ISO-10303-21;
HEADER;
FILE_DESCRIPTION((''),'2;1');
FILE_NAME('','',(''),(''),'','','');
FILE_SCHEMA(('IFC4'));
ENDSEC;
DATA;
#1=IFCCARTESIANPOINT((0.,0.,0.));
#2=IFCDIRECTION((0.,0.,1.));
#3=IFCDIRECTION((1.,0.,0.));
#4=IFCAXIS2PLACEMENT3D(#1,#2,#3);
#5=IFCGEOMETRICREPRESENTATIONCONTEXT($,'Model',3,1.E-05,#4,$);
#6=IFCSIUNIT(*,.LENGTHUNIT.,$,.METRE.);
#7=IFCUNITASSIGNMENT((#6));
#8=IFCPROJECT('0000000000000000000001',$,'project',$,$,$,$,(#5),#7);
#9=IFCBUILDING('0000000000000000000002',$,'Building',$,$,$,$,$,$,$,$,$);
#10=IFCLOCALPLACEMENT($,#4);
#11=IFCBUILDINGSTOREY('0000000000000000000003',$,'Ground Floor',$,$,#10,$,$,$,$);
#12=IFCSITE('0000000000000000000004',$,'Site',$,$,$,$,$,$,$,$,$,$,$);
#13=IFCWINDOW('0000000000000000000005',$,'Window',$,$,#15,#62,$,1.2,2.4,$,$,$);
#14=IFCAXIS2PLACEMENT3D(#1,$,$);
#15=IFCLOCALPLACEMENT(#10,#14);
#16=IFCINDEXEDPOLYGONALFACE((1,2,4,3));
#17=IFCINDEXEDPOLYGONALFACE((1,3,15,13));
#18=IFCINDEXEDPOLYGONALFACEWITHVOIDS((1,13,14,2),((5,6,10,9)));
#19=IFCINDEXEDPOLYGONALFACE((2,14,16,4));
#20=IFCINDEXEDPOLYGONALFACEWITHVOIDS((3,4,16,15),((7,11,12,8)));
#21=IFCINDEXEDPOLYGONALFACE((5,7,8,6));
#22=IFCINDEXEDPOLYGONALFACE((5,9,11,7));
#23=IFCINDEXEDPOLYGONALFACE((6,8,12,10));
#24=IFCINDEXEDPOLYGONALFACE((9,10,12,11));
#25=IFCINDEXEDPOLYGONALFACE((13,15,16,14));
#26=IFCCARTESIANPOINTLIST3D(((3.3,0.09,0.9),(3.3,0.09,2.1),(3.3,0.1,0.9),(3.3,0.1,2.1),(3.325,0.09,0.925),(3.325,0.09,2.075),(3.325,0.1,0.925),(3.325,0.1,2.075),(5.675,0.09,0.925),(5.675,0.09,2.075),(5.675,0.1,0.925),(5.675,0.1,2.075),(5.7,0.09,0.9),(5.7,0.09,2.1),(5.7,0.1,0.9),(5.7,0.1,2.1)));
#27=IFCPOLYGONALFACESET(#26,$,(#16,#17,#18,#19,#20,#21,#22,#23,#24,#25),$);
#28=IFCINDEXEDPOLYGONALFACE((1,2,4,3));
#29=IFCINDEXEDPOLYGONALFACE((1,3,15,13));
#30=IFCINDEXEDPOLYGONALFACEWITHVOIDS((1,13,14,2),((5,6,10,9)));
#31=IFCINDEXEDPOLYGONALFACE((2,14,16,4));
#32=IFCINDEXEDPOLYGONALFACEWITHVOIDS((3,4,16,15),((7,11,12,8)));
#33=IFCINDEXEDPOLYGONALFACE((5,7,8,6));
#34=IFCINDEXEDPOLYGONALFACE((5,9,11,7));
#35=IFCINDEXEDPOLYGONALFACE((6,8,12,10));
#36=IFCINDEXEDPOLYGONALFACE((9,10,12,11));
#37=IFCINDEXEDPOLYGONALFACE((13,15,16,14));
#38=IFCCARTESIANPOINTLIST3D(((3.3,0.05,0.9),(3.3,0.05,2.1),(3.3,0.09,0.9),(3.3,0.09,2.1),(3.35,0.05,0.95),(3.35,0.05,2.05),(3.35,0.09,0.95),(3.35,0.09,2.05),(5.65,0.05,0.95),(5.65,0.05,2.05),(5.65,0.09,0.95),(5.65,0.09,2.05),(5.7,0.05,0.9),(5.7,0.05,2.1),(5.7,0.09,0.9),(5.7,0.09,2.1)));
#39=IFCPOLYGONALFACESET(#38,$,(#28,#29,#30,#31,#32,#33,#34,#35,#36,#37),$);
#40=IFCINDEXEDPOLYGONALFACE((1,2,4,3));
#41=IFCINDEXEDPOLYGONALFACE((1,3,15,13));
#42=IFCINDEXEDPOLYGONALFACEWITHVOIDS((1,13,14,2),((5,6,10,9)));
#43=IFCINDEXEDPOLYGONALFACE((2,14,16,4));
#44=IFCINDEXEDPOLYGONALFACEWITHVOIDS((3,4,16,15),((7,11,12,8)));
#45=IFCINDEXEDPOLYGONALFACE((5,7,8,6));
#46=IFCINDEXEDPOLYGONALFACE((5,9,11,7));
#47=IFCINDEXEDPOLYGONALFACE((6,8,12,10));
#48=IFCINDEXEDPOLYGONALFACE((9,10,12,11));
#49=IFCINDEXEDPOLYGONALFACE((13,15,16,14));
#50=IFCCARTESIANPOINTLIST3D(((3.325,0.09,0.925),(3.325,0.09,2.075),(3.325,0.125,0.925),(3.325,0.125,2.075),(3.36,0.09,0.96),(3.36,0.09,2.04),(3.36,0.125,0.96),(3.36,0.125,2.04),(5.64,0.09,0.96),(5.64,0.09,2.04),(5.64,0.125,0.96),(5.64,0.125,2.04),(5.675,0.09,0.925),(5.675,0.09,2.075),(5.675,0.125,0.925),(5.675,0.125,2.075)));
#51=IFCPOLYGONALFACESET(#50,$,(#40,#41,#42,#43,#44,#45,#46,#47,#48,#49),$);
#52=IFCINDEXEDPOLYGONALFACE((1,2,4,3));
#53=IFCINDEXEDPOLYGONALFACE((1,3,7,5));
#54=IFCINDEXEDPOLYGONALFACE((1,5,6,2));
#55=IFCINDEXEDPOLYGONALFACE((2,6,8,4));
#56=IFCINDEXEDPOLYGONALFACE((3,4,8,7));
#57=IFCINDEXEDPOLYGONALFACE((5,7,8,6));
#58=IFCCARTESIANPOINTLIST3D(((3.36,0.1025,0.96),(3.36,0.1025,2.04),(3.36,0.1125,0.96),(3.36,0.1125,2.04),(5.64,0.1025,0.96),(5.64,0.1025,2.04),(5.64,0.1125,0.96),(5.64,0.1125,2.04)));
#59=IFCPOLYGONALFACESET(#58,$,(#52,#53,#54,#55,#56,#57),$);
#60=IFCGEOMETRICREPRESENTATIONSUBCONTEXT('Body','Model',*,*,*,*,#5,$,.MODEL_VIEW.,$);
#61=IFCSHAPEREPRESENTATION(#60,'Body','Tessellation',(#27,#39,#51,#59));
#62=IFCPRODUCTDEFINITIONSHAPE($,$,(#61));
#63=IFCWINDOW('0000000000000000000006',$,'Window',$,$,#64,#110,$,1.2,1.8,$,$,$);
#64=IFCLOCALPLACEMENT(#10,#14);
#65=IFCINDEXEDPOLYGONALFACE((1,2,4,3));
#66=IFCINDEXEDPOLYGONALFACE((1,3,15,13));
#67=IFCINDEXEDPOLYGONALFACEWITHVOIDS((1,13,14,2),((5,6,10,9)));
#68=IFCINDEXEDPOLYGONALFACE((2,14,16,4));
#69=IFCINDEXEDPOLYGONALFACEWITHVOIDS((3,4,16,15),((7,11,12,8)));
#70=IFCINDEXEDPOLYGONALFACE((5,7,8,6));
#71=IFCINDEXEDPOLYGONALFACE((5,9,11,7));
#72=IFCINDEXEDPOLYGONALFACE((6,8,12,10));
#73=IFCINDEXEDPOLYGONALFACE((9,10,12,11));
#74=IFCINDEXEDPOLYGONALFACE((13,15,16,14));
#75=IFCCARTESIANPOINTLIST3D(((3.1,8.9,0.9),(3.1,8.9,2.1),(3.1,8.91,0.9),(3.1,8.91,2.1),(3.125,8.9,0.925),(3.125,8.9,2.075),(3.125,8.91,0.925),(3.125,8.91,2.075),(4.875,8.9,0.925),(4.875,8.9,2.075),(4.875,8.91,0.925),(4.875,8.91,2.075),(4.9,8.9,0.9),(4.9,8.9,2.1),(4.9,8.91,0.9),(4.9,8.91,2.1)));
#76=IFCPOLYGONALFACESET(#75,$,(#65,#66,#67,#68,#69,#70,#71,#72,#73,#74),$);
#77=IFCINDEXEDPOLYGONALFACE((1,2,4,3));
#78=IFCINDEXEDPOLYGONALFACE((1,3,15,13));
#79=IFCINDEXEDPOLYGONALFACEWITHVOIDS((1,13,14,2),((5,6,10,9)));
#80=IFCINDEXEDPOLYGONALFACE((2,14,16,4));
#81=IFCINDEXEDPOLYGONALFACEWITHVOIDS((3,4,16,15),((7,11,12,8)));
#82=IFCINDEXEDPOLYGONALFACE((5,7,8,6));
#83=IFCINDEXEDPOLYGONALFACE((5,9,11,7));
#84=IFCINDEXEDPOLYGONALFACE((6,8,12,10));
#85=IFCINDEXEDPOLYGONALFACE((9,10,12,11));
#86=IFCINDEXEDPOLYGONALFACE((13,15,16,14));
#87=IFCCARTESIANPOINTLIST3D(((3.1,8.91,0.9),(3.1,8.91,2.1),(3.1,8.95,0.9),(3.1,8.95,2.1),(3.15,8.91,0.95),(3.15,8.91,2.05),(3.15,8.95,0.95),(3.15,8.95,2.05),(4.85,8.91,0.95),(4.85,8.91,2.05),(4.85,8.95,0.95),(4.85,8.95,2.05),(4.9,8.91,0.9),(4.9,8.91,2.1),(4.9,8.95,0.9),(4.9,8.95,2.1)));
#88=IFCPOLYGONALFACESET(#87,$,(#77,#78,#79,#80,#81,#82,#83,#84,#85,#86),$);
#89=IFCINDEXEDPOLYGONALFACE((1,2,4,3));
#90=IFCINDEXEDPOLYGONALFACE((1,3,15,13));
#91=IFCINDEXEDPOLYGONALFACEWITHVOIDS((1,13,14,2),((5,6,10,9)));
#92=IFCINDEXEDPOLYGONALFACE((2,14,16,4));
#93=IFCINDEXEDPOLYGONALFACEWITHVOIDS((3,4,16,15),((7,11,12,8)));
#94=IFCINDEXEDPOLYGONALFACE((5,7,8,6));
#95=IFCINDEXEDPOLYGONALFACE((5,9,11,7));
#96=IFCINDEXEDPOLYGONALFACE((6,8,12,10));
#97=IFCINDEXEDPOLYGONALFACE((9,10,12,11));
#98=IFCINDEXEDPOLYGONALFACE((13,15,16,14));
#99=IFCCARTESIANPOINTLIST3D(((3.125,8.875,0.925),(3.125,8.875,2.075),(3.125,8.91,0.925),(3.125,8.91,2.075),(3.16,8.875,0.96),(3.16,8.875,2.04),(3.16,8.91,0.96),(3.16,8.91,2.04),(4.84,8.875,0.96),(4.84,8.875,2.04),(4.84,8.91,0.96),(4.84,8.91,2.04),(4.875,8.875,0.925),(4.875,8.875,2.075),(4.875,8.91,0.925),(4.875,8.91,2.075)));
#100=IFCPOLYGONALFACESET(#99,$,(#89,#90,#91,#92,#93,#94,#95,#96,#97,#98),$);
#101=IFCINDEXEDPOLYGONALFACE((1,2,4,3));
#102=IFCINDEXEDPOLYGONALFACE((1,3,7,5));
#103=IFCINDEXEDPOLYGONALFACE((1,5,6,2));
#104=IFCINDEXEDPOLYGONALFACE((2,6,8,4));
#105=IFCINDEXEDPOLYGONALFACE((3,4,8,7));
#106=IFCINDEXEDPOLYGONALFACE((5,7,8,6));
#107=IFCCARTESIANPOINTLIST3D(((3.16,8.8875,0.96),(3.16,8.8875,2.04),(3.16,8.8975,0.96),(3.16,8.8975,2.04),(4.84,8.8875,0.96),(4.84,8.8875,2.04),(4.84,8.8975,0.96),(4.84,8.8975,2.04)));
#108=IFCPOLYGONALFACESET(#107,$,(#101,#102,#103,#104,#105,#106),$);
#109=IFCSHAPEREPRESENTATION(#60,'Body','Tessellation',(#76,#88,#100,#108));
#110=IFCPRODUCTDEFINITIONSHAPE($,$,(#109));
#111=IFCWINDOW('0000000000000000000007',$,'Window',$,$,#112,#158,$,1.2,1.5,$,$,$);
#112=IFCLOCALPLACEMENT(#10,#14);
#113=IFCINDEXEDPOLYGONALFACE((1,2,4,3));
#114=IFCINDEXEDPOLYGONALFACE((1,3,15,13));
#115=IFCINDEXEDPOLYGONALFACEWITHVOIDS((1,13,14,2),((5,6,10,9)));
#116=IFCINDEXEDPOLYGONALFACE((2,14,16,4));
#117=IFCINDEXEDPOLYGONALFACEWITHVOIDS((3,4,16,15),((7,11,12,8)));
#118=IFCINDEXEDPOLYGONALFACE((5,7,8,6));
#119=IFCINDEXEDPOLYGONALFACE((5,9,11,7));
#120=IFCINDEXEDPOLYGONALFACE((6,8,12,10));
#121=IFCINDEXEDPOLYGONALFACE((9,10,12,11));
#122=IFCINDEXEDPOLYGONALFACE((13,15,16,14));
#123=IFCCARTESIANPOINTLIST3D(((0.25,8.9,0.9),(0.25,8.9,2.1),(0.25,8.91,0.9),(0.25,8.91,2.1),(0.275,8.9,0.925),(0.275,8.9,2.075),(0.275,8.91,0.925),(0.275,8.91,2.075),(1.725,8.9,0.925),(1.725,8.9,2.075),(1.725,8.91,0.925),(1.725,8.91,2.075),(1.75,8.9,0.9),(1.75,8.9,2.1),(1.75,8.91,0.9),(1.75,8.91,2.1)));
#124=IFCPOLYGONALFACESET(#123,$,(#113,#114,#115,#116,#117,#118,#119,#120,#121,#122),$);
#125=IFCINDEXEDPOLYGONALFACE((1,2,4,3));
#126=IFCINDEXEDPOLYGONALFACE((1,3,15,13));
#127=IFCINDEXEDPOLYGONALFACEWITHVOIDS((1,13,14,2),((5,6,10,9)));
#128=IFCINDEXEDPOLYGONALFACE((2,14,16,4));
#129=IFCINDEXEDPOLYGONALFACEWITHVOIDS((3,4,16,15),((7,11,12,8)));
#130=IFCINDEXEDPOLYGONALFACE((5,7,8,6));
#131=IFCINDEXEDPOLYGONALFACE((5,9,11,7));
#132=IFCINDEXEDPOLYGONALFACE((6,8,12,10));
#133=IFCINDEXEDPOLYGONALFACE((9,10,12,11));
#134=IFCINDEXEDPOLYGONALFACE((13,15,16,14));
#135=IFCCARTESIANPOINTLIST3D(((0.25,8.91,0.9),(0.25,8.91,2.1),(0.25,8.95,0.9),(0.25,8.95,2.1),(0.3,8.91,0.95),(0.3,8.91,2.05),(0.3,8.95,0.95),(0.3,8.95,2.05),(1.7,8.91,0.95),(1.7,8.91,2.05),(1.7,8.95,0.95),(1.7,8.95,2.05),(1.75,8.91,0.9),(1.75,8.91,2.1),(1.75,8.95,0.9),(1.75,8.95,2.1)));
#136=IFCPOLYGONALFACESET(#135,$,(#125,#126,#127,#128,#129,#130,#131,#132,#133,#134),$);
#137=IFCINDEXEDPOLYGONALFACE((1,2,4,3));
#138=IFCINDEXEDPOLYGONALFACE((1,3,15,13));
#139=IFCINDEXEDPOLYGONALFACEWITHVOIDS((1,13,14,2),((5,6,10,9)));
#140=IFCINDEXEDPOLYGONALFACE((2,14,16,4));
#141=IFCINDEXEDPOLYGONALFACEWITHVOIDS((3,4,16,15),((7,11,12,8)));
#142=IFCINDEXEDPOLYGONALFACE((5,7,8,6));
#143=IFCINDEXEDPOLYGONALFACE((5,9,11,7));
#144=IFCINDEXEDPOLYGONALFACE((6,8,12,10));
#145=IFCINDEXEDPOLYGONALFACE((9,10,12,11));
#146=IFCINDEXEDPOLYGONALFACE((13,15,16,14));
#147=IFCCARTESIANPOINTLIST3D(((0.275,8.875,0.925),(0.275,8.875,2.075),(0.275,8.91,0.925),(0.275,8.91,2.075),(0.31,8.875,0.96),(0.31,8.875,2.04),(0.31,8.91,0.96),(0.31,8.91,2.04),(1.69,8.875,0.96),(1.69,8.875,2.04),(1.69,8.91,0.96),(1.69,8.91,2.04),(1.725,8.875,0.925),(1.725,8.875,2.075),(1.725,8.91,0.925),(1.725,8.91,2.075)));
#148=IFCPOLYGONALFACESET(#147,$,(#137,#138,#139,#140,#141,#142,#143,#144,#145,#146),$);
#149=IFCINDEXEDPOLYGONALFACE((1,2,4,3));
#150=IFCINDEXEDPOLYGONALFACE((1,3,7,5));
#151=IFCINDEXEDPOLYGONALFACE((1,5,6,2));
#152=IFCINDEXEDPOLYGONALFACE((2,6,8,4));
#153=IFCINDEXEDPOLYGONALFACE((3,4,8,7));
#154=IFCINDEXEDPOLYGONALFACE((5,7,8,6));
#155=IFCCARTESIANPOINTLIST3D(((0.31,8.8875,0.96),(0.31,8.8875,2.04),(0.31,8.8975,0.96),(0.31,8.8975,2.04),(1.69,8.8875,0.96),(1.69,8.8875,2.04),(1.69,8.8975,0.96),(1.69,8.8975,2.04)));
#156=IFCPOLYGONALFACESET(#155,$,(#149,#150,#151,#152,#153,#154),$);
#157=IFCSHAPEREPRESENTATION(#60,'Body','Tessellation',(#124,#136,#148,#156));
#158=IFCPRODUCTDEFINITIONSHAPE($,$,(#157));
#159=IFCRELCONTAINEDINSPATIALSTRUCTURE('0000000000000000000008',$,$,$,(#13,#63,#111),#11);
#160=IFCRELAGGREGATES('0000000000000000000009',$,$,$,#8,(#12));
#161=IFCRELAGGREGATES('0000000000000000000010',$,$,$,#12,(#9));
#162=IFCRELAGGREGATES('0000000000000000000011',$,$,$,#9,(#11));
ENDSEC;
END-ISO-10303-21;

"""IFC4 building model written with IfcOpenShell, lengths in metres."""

from ifc_helpers import new_model, si_unit, frame, origin_with_axes, place, context, subcontext, project, spatial, line, indexed_curve, outline, extrude, element, save


model = new_model("IFC4")

# Units and contexts
model_context = context("Model", 3, precision=1e-05, world=origin_with_axes())
body_context = subcontext(model_context, "Body", "Model", "MODEL_VIEW")
ifc_project = project(units=[si_unit("LENGTHUNIT", "METRE")], contexts=[model_context])

# Site, building, storey
site = spatial("IfcSite", under=ifc_project, Name="Site")
building = spatial("IfcBuilding", under=site, Name="Building")
storey_placement = place(None, origin_with_axes())
storey = spatial("IfcBuildingStorey", under=building, at=storey_placement, Name="Ground Floor")

# Windows
window_1_placement = place(storey_placement, frame((3.3, 0.0, 0.9), z_axis=(0.0, 0.0, 1.0), x_axis=(1.0, 0.0, 0.0)))
element("IfcWindow", 1, at=window_1_placement, inside=storey, Name="Window", OverallHeight=1.2, OverallWidth=2.4, context=body_context, shape_type="SweptSolid", body=[
    extrude(outline(indexed_curve([(0.0, 0.0), (2.4, 0.0), (2.4, 1.2), (0.0, 1.2)], segments=[line(1, 2, 3, 4, 1)]), holes=[indexed_curve([(0.025, 0.025), (2.375, 0.025), (2.375, 1.175), (0.025, 1.175)], segments=[line(1, 2, 3, 4, 1)])]), frame((0.0, 0.09, 0.0), z_axis=(0.0, -1.0, 0.0), x_axis=(1.0, 0.0, 0.0)), (0.0, 0.0, -1.0), 0.01),
    extrude(outline(indexed_curve([(0.0, 0.0), (2.4, 0.0), (2.4, 1.2), (0.0, 1.2)], segments=[line(1, 2, 3, 4, 1)]), holes=[indexed_curve([(0.05, 0.05), (2.35, 0.05), (2.35, 1.15), (0.05, 1.15)], segments=[line(1, 2, 3, 4, 1)])]), frame((0.0, 0.05, 0.0), z_axis=(0.0, -1.0, 0.0), x_axis=(1.0, 0.0, 0.0)), (0.0, 0.0, -1.0), 0.04),
    extrude(outline(indexed_curve([(0.0, 0.0), (2.35, 0.0), (2.35, 1.15), (0.0, 1.15)], segments=[line(1, 2, 3, 4, 1)]), holes=[indexed_curve([(0.035, 0.035), (2.315, 0.035), (2.315, 1.115), (0.035, 1.115)], segments=[line(1, 2, 3, 4, 1)])]), frame((0.025, 0.09, 0.025), z_axis=(0.0, -1.0, 0.0), x_axis=(1.0, 0.0, 0.0)), (0.0, 0.0, -1.0), 0.035),
    extrude(outline(indexed_curve([(0.035, 0.035), (2.315, 0.035), (2.315, 1.115), (0.035, 1.115)], segments=[line(1, 2, 3, 4, 1)])), frame((0.025, 0.1025, 0.025), z_axis=(0.0, -1.0, 0.0), x_axis=(1.0, 0.0, 0.0)), (0.0, 0.0, -1.0), 0.01),
])
window_2_placement = place(storey_placement, frame((4.9, 9.0, 0.9), z_axis=(0.0, 0.0, 1.0), x_axis=(-1.0, 0.0, 0.0)))
element("IfcWindow", 2, at=window_2_placement, inside=storey, Name="Window", OverallHeight=1.2, OverallWidth=1.8, context=body_context, shape_type="SweptSolid", body=[
    extrude(outline(indexed_curve([(0.0, 0.0), (1.8, 0.0), (1.8, 1.2), (0.0, 1.2)], segments=[line(1, 2, 3, 4, 1)]), holes=[indexed_curve([(0.025, 0.025), (1.775, 0.025), (1.775, 1.175), (0.025, 1.175)], segments=[line(1, 2, 3, 4, 1)])]), frame((0.0, 0.09, 0.0), z_axis=(0.0, -1.0, 0.0), x_axis=(1.0, 0.0, 0.0)), (0.0, 0.0, -1.0), 0.01),
    extrude(outline(indexed_curve([(0.0, 0.0), (1.8, 0.0), (1.8, 1.2), (0.0, 1.2)], segments=[line(1, 2, 3, 4, 1)]), holes=[indexed_curve([(0.05, 0.05), (1.75, 0.05), (1.75, 1.15), (0.05, 1.15)], segments=[line(1, 2, 3, 4, 1)])]), frame((0.0, 0.05, 0.0), z_axis=(0.0, -1.0, 0.0), x_axis=(1.0, 0.0, 0.0)), (0.0, 0.0, -1.0), 0.04),
    extrude(outline(indexed_curve([(0.0, 0.0), (1.75, 0.0), (1.75, 1.15), (0.0, 1.15)], segments=[line(1, 2, 3, 4, 1)]), holes=[indexed_curve([(0.035, 0.035), (1.715, 0.035), (1.715, 1.115), (0.035, 1.115)], segments=[line(1, 2, 3, 4, 1)])]), frame((0.025, 0.09, 0.025), z_axis=(0.0, -1.0, 0.0), x_axis=(1.0, 0.0, 0.0)), (0.0, 0.0, -1.0), 0.035),
    extrude(outline(indexed_curve([(0.035, 0.035), (1.715, 0.035), (1.715, 1.115), (0.035, 1.115)], segments=[line(1, 2, 3, 4, 1)])), frame((0.025, 0.1025, 0.025), z_axis=(0.0, -1.0, 0.0), x_axis=(1.0, 0.0, 0.0)), (0.0, 0.0, -1.0), 0.01),
])
window_3_placement = place(storey_placement, frame((1.75, 9.0, 0.9), z_axis=(0.0, 0.0, 1.0), x_axis=(-1.0, 0.0, 0.0)))
element("IfcWindow", 3, at=window_3_placement, inside=storey, Name="Window", OverallHeight=1.2, OverallWidth=1.5, context=body_context, shape_type="SweptSolid", body=[
    extrude(outline(indexed_curve([(0.0, 0.0), (1.5, 0.0), (1.5, 1.2), (0.0, 1.2)], segments=[line(1, 2, 3, 4, 1)]), holes=[indexed_curve([(0.025, 0.025), (1.475, 0.025), (1.475, 1.175), (0.025, 1.175)], segments=[line(1, 2, 3, 4, 1)])]), frame((0.0, 0.09, 0.0), z_axis=(0.0, -1.0, 0.0), x_axis=(1.0, 0.0, 0.0)), (0.0, 0.0, -1.0), 0.01),
    extrude(outline(indexed_curve([(0.0, 0.0), (1.5, 0.0), (1.5, 1.2), (0.0, 1.2)], segments=[line(1, 2, 3, 4, 1)]), holes=[indexed_curve([(0.05, 0.05), (1.45, 0.05), (1.45, 1.15), (0.05, 1.15)], segments=[line(1, 2, 3, 4, 1)])]), frame((0.0, 0.05, 0.0), z_axis=(0.0, -1.0, 0.0), x_axis=(1.0, 0.0, 0.0)), (0.0, 0.0, -1.0), 0.04),
    extrude(outline(indexed_curve([(0.0, 0.0), (1.45, 0.0), (1.45, 1.15), (0.0, 1.15)], segments=[line(1, 2, 3, 4, 1)]), holes=[indexed_curve([(0.035, 0.035), (1.415, 0.035), (1.415, 1.115), (0.035, 1.115)], segments=[line(1, 2, 3, 4, 1)])]), frame((0.025, 0.09, 0.025), z_axis=(0.0, -1.0, 0.0), x_axis=(1.0, 0.0, 0.0)), (0.0, 0.0, -1.0), 0.035),
    extrude(outline(indexed_curve([(0.035, 0.035), (1.415, 0.035), (1.415, 1.115), (0.035, 1.115)], segments=[line(1, 2, 3, 4, 1)])), frame((0.025, 0.1025, 0.025), z_axis=(0.0, -1.0, 0.0), x_axis=(1.0, 0.0, 0.0)), (0.0, 0.0, -1.0), 0.01),
])

save(model, "model.ifc")
